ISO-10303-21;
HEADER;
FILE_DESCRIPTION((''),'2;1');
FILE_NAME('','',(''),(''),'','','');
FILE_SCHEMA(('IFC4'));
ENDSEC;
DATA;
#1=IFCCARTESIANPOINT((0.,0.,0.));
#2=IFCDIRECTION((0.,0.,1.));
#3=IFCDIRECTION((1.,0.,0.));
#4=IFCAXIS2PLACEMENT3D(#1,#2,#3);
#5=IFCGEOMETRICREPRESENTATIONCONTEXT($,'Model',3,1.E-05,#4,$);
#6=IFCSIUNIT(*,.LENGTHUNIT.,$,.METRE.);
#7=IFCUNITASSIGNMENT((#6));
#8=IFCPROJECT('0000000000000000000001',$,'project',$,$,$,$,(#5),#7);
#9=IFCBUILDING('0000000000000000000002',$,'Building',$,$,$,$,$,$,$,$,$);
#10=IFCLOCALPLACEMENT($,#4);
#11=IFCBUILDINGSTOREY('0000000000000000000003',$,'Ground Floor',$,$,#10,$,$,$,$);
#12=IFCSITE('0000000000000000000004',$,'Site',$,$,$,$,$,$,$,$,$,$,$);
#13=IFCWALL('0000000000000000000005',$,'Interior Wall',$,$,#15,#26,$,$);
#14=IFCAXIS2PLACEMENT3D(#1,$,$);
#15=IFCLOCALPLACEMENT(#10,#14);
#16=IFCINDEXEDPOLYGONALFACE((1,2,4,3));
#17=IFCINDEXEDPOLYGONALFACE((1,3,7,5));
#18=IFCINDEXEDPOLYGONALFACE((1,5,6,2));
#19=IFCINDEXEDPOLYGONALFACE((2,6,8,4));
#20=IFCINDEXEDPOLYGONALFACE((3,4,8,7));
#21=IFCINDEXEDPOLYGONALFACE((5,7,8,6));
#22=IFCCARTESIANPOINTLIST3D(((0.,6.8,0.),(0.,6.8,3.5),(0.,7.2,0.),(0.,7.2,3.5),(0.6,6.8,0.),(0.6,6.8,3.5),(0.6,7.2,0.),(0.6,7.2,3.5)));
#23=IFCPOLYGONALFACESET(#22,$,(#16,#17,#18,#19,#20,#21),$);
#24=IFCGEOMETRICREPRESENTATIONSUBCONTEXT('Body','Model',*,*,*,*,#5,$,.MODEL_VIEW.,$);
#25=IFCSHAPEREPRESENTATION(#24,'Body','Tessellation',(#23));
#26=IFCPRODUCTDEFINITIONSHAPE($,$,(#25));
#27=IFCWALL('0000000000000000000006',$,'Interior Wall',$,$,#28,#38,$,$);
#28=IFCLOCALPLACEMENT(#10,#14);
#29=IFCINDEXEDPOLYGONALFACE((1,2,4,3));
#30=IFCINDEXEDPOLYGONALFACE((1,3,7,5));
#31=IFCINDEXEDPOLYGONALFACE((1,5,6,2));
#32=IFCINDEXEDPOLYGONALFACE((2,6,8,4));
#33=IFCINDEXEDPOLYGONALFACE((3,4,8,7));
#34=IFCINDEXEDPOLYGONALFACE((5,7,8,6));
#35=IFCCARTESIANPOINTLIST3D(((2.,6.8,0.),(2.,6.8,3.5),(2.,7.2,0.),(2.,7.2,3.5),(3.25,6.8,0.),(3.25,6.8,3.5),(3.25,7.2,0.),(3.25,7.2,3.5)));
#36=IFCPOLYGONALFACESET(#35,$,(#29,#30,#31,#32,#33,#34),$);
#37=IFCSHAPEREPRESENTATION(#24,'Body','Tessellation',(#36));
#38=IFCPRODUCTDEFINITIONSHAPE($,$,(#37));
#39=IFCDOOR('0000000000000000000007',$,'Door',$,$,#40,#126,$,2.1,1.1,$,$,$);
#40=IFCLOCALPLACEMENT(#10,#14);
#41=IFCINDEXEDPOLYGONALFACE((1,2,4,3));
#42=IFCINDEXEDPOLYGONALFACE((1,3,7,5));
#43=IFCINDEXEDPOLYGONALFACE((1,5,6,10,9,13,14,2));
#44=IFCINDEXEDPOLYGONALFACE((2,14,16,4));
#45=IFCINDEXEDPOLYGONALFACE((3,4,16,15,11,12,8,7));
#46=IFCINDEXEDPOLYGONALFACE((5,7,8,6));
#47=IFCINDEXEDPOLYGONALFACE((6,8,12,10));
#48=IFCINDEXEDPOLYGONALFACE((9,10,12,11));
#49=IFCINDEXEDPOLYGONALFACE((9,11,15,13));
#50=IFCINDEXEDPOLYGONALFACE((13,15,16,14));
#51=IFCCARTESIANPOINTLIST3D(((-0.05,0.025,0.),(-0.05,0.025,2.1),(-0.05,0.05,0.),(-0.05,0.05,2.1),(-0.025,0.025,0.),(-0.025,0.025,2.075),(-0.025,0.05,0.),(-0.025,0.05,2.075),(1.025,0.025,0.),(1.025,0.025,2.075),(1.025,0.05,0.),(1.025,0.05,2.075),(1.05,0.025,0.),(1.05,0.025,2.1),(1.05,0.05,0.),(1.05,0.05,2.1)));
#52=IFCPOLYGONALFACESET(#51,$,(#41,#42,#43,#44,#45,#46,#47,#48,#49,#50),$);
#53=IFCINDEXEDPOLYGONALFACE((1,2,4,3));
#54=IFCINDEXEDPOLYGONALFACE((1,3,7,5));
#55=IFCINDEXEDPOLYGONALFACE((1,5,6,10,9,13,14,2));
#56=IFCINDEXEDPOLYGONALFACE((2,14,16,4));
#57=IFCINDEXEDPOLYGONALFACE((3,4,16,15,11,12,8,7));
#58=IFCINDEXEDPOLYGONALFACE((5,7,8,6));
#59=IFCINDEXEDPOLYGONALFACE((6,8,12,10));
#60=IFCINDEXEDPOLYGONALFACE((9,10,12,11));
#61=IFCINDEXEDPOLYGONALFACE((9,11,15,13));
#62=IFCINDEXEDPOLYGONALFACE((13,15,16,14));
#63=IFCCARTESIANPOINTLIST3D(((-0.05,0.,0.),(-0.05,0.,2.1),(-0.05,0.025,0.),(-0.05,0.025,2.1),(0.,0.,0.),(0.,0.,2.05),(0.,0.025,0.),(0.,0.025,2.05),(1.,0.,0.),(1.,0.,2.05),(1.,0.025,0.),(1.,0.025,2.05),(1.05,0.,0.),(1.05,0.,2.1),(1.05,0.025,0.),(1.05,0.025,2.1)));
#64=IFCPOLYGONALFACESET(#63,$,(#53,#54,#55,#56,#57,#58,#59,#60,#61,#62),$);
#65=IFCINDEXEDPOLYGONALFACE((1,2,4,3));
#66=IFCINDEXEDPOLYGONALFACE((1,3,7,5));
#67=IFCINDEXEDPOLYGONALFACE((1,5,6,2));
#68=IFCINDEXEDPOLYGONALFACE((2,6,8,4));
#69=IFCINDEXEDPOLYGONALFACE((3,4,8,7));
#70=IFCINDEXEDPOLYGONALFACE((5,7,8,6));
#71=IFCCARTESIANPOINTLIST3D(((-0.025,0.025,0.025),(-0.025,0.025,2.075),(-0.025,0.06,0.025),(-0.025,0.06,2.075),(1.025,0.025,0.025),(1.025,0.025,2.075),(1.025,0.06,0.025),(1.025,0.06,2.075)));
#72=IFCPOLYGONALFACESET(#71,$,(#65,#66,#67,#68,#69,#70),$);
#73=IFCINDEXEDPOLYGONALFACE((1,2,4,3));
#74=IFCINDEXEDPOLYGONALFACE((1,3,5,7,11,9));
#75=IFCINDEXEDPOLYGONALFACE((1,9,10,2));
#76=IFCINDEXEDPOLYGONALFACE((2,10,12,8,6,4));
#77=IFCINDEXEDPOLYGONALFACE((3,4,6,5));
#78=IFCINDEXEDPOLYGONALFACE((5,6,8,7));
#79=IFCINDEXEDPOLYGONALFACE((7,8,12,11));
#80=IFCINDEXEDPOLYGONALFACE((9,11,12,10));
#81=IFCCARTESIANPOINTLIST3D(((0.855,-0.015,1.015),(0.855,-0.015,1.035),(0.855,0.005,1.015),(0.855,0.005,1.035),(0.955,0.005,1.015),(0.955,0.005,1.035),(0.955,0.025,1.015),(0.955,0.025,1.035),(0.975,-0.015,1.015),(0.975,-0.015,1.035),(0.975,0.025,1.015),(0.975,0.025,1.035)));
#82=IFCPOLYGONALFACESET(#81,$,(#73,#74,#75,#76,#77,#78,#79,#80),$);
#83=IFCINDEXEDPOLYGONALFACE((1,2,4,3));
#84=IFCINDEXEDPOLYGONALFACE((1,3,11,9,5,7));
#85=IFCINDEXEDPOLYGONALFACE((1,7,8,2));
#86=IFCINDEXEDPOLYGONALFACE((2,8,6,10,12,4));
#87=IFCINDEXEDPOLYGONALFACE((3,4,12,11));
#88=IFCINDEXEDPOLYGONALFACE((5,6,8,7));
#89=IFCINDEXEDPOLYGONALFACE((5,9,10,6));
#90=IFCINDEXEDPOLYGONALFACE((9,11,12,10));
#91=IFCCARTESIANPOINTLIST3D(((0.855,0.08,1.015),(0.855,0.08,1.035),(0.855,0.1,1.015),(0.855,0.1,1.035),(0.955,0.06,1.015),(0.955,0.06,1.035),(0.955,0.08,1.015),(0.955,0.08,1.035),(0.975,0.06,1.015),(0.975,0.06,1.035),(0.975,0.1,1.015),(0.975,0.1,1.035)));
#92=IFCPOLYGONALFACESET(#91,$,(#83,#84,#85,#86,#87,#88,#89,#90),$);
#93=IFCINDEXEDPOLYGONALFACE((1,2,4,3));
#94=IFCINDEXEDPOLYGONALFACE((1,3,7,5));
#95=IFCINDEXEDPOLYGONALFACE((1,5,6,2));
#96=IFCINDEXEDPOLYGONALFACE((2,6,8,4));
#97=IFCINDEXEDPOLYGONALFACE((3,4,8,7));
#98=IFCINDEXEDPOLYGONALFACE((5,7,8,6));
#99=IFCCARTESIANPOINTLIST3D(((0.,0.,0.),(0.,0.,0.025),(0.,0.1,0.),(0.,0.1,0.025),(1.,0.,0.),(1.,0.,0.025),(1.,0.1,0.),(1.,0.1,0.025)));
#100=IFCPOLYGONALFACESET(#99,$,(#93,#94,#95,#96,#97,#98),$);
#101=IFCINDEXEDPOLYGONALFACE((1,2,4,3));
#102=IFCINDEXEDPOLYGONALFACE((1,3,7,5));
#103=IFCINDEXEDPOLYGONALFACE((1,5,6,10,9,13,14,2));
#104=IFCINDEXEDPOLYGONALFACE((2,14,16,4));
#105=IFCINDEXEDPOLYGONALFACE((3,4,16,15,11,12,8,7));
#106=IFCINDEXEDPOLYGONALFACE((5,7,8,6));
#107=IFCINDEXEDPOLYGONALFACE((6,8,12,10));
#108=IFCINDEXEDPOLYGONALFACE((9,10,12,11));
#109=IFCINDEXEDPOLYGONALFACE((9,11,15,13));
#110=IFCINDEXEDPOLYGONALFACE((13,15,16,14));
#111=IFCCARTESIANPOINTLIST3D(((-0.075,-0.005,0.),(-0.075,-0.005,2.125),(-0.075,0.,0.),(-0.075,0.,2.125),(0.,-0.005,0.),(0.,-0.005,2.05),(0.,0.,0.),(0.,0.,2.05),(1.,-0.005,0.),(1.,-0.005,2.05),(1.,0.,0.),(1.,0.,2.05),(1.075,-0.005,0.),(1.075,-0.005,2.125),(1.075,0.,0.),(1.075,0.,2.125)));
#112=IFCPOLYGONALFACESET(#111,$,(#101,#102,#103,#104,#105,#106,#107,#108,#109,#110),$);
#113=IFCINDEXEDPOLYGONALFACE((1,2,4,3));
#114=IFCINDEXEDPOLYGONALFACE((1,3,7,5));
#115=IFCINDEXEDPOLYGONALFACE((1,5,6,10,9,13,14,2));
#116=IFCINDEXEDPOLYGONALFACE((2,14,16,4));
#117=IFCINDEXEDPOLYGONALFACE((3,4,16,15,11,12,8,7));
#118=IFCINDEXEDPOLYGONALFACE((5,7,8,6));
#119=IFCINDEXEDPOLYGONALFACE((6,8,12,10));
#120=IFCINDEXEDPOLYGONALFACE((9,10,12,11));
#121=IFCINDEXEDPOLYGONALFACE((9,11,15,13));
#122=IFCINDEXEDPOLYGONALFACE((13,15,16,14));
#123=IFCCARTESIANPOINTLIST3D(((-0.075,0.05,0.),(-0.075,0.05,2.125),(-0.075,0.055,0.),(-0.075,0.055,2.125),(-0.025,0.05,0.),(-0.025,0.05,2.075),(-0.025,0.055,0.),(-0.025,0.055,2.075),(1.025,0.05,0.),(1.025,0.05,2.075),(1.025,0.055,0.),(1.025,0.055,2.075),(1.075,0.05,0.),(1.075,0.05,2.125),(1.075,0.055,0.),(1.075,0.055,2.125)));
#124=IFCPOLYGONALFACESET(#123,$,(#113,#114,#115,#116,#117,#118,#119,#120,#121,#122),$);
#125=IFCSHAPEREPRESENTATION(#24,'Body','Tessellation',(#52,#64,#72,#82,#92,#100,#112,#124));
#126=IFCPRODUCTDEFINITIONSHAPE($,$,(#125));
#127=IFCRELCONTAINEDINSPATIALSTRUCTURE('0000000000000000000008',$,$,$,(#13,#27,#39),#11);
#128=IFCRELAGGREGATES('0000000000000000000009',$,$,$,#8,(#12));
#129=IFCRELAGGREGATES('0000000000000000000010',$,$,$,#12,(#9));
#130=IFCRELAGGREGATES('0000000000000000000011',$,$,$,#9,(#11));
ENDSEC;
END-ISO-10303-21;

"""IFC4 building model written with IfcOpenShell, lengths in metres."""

from ifc_helpers import new_model, si_unit, frame, origin_with_axes, place, context, subcontext, project, spatial, line, indexed_curve, outline, extrude, element, save


model = new_model("IFC4")

# Units and contexts
model_context = context("Model", 3, precision=1e-05, world=origin_with_axes())
body_context = subcontext(model_context, "Body", "Model", "MODEL_VIEW")
ifc_project = project(units=[si_unit("LENGTHUNIT", "METRE")], contexts=[model_context])

# Site, building, storey
site = spatial("IfcSite", under=ifc_project, Name="Site")
building = spatial("IfcBuilding", under=site, Name="Building")
storey_placement = place(None, origin_with_axes())
storey = spatial("IfcBuildingStorey", under=building, at=storey_placement, Name="Ground Floor")

# Walls
for number, where, z_axis, x_axis, name in (
    (1, (0.6, 7.0, 0.0), (0.0, 0.0, 1.0), (-1.0, 0.0, 0.0), "Interior Wall"),
):
    element("IfcWall", number, at=place(storey_placement, frame(where, z_axis=z_axis, x_axis=x_axis)), inside=storey, Name=name, context=body_context, shape_type="SweptSolid", body=[
        extrude(outline(indexed_curve([(0.0, 0.0), (0.0, 0.4), (0.6, 0.4), (0.6, 0.0), (0.0, 0.0)], self_intersect=False)), frame((0.0, -0.2, 0.0), z_axis=(0.0, 0.0, 1.0), x_axis=(1.0, 0.0, 0.0)), (0.0, 0.0, 1.0), 3.5),
    ])
wall_1_placement = place(storey_placement, frame((3.25, 7.0, 0.0), z_axis=(0.0, 0.0, 1.0), x_axis=(-1.0, 0.0, 0.0)))
element("IfcWall", 2, at=wall_1_placement, inside=storey, Name="Interior Wall", context=body_context, shape_type="SweptSolid", body=[
    extrude(outline(indexed_curve([(0.0, 0.0), (0.0, 0.4), (1.25, 0.4), (1.25, 0.0), (0.0, 0.0)], self_intersect=False)), frame((0.0, -0.2, 0.0), z_axis=(0.0, 0.0, 1.0), x_axis=(1.0, 0.0, 0.0)), (0.0, 0.0, 1.0), 3.5),
])

# Door
door_1_placement = place(storey_placement, frame((-0.05, 0.0, 0.0), z_axis=(0.0, 0.0, 1.0), x_axis=(1.0, 0.0, 0.0)))
element("IfcDoor", 3, at=door_1_placement, inside=storey, Name="Door", OverallHeight=2.1, OverallWidth=1.1, context=body_context, shape_type="SweptSolid", body=[
    extrude(outline(indexed_curve([(0.0, 0.0), (0.0, 2.1), (1.1, 2.1), (1.1, 0.0), (1.075, 0.0), (1.075, 2.075), (0.025, 2.075), (0.025, 0.0)], segments=[line(1, 2, 3, 4, 5, 6, 7, 8, 1)])), frame((0.0, 0.025, 0.0), z_axis=(0.0, -1.0, 0.0), x_axis=(1.0, 0.0, 0.0)), (0.0, 0.0, -1.0), 0.025),
    extrude(outline(indexed_curve([(0.0, 0.0), (0.0, 2.1), (1.1, 2.1), (1.1, 0.0), (1.05, 0.0), (1.05, 2.05), (0.05, 2.05), (0.05, 0.0)], segments=[line(1, 2, 3, 4, 5, 6, 7, 8, 1)])), frame((0.0, 0.0, 0.0), z_axis=(0.0, -1.0, 0.0), x_axis=(1.0, 0.0, 0.0)), (0.0, 0.0, -1.0), 0.025),
    extrude(outline(indexed_curve([(0.0, 0.0), (1.05, 0.0), (1.05, 0.035), (0.0, 0.035)], segments=[line(1, 2, 3, 4, 1)])), frame((0.025, 0.025, 0.025), z_axis=(0.0, 0.0, 1.0), x_axis=(1.0, 0.0, 0.0)), (0.0, 0.0, 1.0), 2.05),
    extrude(outline(indexed_curve([(0.0, 0.0), (0.0, -0.04), (-0.12, -0.04), (-0.12, -0.02), (-0.02, -0.02), (-0.02, 0.0)], segments=[line(1, 2, 3, 4, 5, 6, 1)])), frame((1.025, 0.025, 1.015), z_axis=(0.0, 0.0, 1.0), x_axis=(1.0, 0.0, 0.0)), (0.0, 0.0, 1.0), 0.02),
    extrude(outline(indexed_curve([(0.0, 0.0), (0.0, 0.04), (-0.12, 0.04), (-0.12, 0.02), (-0.02, 0.02), (-0.02, 0.0)], segments=[line(1, 2, 3, 4, 5, 6, 1)])), frame((1.025, 0.06, 1.015), z_axis=(0.0, 0.0, 1.0), x_axis=(1.0, 0.0, 0.0)), (0.0, 0.0, 1.0), 0.02),
    extrude(outline(indexed_curve([(0.0, 0.0), (1.0, 0.0), (1.0, 0.1), (0.0, 0.1)], segments=[line(1, 2, 3, 4, 1)])), frame((0.05, 0.0, 0.0), z_axis=(0.0, 0.0, 1.0), x_axis=(1.0, 0.0, 0.0)), (0.0, 0.0, 1.0), 0.025),
    extrude(outline(indexed_curve([(0.0, 0.0), (0.0, 2.125), (1.15, 2.125), (1.15, 0.0), (1.075, 0.0), (1.075, 2.05), (0.075, 2.05), (0.075, 0.0)], segments=[line(1, 2, 3, 4, 5, 6, 7, 8, 1)])), frame((-0.025, -0.005, 0.0), z_axis=(0.0, -1.0, 0.0), x_axis=(1.0, 0.0, 0.0)), (0.0, 0.0, -1.0), 0.005),
    extrude(outline(indexed_curve([(0.0, 0.0), (0.0, 2.125), (1.15, 2.125), (1.15, 0.0), (1.1, 0.0), (1.1, 2.075), (0.05, 2.075), (0.05, 0.0)], segments=[line(1, 2, 3, 4, 5, 6, 7, 8, 1)])), frame((-0.025, 0.05, 0.0), z_axis=(0.0, -1.0, 0.0), x_axis=(1.0, 0.0, 0.0)), (0.0, 0.0, -1.0), 0.005),
])

save(model, "model.ifc")
